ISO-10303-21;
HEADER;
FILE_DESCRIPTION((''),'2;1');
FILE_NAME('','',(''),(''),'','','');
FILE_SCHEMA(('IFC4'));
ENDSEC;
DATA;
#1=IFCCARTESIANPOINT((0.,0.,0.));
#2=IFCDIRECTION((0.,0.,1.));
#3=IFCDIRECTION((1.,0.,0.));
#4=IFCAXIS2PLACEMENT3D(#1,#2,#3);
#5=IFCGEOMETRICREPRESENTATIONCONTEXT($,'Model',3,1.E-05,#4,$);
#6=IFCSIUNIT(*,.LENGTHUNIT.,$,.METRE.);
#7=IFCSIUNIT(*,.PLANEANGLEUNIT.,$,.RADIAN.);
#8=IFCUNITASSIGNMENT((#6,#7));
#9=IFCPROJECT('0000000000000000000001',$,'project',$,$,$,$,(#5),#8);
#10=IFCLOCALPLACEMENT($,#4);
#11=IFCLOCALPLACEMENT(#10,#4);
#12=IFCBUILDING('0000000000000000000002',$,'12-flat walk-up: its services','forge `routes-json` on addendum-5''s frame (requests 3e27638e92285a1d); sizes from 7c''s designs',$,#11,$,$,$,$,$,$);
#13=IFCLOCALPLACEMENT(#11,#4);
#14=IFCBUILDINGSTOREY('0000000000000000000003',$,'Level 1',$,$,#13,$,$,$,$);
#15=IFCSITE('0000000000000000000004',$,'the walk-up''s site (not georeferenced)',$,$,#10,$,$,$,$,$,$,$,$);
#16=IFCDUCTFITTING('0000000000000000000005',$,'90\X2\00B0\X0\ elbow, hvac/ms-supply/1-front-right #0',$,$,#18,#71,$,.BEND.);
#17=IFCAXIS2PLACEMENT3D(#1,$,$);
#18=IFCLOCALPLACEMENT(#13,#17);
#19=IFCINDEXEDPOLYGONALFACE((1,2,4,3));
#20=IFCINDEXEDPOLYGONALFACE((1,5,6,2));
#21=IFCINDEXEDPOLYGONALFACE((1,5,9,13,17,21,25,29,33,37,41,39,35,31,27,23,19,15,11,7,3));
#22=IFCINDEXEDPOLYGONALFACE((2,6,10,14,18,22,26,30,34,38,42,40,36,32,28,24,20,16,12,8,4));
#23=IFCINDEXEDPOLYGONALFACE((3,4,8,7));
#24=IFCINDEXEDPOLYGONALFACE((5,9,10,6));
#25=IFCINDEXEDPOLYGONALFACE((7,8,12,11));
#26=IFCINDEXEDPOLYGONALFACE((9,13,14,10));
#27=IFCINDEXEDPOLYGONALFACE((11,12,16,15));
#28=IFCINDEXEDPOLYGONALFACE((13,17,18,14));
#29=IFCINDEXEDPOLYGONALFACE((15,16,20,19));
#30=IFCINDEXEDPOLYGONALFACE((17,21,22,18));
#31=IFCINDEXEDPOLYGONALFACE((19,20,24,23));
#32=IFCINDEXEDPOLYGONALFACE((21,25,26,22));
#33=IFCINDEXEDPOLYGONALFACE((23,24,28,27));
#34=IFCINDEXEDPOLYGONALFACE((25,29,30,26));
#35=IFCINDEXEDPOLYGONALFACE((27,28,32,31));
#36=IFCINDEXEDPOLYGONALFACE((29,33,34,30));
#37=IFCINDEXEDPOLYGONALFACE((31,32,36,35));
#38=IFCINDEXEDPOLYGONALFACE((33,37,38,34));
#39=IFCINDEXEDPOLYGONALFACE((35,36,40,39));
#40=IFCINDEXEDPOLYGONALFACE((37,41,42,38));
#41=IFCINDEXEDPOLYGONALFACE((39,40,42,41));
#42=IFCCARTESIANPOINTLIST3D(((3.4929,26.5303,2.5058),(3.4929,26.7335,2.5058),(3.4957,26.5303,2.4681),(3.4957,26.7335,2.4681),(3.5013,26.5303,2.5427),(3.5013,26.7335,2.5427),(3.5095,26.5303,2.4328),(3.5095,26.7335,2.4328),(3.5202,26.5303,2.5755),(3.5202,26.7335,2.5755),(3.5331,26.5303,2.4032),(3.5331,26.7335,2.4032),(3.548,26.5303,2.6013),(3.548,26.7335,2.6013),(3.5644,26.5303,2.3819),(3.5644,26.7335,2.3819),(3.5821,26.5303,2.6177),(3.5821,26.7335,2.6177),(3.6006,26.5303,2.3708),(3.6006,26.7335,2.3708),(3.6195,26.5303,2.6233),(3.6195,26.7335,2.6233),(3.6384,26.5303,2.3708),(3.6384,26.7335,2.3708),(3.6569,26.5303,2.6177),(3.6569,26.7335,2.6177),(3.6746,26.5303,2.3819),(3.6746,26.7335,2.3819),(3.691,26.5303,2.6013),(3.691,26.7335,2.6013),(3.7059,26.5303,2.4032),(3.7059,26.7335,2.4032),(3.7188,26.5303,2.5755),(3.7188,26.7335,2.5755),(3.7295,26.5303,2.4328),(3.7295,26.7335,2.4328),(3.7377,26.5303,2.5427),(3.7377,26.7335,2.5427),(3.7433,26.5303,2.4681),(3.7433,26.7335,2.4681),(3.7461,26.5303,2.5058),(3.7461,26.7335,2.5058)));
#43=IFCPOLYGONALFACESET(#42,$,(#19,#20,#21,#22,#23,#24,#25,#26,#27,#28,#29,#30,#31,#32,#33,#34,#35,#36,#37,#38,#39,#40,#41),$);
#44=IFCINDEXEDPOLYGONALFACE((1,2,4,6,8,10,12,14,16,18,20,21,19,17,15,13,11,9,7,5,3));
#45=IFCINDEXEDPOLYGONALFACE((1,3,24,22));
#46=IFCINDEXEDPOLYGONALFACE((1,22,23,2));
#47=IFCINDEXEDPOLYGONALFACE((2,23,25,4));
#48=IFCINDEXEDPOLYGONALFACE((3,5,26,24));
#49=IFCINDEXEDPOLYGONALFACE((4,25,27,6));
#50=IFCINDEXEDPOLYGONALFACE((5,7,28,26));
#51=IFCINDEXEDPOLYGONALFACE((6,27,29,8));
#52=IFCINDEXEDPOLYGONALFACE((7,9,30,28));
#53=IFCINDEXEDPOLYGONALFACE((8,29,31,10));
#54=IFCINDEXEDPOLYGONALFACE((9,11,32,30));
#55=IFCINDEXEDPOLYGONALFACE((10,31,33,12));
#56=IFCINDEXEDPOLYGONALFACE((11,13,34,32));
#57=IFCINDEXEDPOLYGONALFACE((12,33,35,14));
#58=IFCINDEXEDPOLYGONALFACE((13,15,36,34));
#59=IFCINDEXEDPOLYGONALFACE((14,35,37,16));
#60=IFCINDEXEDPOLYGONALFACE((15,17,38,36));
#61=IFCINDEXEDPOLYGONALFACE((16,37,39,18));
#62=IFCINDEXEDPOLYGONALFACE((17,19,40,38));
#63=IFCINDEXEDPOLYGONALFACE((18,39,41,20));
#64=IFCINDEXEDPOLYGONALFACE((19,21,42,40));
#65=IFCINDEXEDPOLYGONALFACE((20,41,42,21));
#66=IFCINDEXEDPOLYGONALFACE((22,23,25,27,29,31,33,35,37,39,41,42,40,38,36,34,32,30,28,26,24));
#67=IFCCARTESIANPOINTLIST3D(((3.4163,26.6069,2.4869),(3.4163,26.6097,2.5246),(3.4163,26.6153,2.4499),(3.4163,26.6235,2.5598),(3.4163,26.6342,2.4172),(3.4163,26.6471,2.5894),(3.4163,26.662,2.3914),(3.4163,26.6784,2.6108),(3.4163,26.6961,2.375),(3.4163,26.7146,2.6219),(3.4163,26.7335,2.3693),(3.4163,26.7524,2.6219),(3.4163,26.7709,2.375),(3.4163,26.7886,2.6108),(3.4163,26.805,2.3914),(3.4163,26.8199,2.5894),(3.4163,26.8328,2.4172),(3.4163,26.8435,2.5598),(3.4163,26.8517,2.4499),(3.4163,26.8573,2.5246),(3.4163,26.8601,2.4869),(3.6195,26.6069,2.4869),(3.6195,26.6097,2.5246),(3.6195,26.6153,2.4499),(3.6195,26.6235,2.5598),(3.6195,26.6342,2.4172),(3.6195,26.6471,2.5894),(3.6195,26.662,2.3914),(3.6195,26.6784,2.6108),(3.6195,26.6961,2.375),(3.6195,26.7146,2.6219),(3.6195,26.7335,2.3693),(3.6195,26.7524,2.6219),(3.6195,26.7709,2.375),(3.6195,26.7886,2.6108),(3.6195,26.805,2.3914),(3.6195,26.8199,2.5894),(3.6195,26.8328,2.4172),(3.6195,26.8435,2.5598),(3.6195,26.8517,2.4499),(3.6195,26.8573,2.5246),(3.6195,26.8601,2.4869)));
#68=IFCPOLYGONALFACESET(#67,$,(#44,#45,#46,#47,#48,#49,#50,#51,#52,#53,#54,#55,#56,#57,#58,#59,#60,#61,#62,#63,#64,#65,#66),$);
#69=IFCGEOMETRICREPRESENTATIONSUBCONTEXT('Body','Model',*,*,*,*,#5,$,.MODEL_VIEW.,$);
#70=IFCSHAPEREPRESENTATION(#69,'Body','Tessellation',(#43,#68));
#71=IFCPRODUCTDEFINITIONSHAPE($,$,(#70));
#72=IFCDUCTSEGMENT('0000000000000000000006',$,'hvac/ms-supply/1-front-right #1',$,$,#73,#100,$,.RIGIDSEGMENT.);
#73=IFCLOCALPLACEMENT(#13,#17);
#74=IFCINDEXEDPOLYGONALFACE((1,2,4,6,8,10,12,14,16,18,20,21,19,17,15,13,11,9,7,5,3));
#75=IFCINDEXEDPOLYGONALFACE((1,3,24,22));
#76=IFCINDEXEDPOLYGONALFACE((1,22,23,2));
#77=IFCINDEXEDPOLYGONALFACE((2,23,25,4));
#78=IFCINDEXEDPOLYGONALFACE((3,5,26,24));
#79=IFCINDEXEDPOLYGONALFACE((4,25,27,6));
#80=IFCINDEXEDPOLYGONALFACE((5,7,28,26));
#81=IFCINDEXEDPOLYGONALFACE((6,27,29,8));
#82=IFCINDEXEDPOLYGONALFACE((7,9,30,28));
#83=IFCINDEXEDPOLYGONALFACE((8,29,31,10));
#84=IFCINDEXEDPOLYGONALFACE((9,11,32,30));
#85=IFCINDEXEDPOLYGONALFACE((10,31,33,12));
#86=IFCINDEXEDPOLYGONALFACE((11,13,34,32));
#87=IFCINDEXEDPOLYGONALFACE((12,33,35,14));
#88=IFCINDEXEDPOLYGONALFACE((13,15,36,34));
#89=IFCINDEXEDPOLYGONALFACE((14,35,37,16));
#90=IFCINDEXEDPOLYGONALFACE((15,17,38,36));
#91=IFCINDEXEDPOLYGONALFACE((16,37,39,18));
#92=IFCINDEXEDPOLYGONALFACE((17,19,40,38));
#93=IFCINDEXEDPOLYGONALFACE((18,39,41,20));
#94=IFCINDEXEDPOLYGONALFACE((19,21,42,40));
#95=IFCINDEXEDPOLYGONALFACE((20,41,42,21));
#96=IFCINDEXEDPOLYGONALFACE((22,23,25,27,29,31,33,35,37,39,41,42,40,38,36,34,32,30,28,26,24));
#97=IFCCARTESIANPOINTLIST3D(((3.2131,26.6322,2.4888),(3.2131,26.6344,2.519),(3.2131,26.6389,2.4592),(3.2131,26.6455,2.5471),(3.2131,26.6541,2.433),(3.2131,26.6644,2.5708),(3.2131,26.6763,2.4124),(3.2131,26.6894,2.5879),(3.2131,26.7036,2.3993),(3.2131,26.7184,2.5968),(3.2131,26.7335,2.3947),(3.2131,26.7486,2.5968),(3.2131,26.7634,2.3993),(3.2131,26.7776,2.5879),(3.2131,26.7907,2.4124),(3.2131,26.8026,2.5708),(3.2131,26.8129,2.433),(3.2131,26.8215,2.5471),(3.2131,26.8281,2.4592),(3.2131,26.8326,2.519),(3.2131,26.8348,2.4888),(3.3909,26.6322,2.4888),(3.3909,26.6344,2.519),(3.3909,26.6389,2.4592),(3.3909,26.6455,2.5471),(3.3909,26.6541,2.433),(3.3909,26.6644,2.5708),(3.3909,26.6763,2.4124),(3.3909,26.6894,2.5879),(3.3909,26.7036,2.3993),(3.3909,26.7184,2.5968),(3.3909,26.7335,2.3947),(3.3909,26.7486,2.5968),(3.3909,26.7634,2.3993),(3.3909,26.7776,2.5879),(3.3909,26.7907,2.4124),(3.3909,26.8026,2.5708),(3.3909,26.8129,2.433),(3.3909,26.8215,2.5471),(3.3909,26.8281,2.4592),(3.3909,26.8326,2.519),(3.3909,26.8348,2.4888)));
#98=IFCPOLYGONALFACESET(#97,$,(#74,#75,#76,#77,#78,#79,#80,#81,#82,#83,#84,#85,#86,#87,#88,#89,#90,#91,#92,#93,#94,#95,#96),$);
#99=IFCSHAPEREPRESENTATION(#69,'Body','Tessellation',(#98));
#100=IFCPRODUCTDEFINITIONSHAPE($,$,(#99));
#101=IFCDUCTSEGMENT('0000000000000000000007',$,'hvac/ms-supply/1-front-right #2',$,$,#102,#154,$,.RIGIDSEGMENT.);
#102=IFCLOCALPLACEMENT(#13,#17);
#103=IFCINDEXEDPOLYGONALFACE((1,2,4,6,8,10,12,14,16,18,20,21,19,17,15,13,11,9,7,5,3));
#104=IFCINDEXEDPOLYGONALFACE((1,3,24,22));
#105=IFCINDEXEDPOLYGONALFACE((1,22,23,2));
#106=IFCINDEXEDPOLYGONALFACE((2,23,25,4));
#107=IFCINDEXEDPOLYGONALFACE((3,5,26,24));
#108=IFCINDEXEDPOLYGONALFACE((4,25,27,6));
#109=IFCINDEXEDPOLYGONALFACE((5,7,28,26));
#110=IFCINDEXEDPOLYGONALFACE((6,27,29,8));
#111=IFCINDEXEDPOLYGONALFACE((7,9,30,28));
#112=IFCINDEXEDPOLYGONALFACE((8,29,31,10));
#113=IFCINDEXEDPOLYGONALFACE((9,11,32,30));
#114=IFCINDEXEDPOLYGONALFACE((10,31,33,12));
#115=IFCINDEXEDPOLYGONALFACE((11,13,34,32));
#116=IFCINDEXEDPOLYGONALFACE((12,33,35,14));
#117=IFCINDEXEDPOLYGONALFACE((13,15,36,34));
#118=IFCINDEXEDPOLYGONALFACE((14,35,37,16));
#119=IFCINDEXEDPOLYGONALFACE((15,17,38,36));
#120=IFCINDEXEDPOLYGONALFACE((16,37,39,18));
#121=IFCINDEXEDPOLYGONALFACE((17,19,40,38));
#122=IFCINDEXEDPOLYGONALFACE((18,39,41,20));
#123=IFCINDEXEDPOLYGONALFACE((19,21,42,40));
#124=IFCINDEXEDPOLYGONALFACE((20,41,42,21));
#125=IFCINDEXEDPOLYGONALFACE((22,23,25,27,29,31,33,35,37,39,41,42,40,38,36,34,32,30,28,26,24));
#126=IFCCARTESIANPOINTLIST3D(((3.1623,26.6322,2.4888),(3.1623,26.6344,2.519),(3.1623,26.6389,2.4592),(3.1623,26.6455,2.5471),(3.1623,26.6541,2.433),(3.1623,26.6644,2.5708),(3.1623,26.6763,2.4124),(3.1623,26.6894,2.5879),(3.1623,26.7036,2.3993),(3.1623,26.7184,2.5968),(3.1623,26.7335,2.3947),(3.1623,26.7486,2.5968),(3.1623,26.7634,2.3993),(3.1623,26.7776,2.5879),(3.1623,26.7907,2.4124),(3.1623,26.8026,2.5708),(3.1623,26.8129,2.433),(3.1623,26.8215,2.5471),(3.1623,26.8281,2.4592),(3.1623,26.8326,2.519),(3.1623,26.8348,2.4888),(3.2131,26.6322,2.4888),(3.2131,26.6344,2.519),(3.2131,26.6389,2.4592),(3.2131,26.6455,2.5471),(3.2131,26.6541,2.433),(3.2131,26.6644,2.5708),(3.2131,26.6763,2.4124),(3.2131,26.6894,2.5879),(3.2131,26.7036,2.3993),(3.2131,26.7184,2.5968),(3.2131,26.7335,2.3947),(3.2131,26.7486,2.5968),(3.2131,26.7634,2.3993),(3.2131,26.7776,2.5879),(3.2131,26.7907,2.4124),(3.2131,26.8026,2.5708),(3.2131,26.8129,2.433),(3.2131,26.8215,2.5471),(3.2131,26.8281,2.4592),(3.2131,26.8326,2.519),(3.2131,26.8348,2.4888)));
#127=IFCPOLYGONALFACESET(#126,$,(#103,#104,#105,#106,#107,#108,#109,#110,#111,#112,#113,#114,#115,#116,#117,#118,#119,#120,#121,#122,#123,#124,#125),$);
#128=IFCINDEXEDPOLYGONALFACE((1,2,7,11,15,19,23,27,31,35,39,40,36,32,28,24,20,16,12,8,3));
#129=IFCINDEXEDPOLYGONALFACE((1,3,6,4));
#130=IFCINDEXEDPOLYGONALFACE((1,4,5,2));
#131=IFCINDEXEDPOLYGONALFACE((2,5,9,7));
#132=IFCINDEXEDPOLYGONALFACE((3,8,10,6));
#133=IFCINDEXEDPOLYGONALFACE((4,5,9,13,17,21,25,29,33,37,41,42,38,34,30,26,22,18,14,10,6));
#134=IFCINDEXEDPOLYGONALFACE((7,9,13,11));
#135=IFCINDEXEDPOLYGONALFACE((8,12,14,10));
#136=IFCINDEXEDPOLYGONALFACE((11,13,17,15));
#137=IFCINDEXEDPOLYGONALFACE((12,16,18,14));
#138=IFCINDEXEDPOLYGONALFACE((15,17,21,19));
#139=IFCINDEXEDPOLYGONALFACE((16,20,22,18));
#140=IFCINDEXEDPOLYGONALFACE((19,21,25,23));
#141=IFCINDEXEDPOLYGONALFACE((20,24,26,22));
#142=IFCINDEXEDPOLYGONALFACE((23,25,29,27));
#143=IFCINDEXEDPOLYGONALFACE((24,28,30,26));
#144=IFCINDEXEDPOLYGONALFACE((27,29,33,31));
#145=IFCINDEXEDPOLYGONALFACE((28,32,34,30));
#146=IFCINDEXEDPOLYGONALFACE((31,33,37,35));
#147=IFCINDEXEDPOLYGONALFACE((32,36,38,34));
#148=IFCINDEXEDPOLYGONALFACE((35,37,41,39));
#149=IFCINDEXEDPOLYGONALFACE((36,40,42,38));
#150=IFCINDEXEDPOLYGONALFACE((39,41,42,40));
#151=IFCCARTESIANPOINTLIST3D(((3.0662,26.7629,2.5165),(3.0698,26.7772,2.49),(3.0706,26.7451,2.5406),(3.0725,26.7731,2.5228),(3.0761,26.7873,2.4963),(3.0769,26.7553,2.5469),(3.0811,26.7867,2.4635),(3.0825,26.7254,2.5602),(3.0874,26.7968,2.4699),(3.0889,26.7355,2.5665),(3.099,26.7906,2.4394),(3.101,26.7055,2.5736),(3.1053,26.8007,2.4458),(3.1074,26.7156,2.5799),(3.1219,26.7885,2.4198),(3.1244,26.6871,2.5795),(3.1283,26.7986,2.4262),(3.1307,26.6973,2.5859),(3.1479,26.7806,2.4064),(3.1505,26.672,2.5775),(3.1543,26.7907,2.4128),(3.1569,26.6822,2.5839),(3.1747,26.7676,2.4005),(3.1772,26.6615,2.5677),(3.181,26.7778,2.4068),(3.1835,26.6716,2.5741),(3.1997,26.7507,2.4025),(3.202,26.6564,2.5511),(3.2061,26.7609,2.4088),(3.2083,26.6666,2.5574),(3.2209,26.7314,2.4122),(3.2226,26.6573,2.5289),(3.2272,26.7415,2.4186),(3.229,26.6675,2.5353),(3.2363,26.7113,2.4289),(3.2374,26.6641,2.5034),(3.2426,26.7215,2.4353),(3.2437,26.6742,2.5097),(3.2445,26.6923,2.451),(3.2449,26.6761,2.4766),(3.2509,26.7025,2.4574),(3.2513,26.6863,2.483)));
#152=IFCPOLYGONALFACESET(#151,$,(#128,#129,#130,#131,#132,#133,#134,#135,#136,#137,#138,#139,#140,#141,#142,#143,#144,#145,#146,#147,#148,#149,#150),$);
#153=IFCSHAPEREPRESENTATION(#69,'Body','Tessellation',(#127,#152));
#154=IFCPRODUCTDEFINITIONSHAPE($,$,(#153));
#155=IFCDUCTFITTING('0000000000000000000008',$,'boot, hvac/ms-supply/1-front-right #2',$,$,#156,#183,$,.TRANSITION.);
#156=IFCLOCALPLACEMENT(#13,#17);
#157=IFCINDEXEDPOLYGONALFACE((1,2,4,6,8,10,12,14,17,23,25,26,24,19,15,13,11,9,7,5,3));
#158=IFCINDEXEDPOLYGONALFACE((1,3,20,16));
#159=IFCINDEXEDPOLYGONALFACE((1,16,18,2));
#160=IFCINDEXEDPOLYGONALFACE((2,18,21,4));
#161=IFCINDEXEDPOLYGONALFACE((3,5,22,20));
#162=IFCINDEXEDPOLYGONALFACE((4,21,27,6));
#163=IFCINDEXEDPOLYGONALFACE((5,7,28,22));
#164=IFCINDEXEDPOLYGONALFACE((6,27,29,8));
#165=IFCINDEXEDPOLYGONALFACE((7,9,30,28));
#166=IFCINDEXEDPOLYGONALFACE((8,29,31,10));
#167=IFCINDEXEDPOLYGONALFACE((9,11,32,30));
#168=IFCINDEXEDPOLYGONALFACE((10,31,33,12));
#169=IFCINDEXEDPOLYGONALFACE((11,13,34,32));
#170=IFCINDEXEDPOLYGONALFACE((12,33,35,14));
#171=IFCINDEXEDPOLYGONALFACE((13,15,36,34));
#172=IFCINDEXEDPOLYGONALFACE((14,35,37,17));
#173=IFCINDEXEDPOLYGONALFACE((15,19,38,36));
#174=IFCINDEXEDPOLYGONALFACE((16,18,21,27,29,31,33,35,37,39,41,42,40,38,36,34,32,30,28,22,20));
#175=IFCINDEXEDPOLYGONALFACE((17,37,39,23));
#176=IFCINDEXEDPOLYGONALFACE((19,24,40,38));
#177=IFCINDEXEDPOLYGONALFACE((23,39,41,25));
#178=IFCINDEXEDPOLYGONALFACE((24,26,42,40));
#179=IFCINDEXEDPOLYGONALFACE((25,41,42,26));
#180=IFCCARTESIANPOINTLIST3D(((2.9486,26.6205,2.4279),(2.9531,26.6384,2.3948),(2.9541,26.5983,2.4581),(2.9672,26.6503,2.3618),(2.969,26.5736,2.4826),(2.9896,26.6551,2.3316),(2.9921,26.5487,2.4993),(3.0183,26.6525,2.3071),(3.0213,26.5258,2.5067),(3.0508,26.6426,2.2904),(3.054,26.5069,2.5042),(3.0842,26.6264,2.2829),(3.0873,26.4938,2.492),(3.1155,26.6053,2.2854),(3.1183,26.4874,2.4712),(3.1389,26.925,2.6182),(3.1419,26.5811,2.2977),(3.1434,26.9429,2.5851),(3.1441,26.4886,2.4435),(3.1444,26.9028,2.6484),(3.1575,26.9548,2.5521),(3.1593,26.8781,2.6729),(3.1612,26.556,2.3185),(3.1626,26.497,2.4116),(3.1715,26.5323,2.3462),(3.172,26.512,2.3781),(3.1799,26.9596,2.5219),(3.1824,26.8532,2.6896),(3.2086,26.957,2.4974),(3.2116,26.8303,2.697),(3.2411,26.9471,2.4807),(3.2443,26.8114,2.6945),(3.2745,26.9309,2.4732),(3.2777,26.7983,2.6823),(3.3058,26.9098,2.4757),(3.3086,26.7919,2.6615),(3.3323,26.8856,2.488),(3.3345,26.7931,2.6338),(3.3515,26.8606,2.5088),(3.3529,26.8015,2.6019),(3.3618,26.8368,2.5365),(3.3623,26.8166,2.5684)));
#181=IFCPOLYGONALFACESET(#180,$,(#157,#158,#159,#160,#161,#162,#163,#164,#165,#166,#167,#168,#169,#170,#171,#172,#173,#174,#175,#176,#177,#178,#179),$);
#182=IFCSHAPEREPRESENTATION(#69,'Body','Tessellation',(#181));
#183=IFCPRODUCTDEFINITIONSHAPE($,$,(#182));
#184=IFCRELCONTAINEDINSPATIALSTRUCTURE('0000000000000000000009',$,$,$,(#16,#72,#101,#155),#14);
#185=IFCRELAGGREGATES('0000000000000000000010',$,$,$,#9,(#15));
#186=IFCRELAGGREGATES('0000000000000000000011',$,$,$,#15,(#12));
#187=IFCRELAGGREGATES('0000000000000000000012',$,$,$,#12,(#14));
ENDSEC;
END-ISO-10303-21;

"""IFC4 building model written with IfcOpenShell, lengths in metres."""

from ifc_helpers import new_model, entity, si_unit, frame, origin_with_axes, place, context, subcontext, project, spatial, element, save


model = new_model("IFC4")

# Units and contexts
model_context = context("Model", 3, precision=1e-05, world=origin_with_axes())
body_context = subcontext(model_context, "Body", "Model", "MODEL_VIEW")
ifc_project = project(units=[si_unit("LENGTHUNIT", "METRE"), si_unit("PLANEANGLEUNIT", "RADIAN")], contexts=[model_context])

# Site, building, storey
site_placement = place(None, origin_with_axes())
site = spatial("IfcSite", under=ifc_project, at=site_placement, Name="the walk-up's site (not georeferenced)")
building_placement = place(site_placement, origin_with_axes())
building = spatial("IfcBuilding", under=site, at=building_placement, Name="12-flat walk-up: its services", Description="forge `routes-json` on addendum-5's frame (requests 3e27638e92285a1d); sizes from 7c's designs")
storey_placement = place(building_placement, origin_with_axes())
storey = spatial("IfcBuildingStorey", under=building, at=storey_placement, Name="Level 1")

# Duct fitting
duct_fitting_1_placement = place(storey_placement, frame((3.6195, 26.5303, 2.4963), z_axis=(0.0, 0.0, 1.0), x_axis=(1.0, 0.0, 0.0)))
element("IfcDuctFitting", 1, at=duct_fitting_1_placement, inside=storey, Name="90° elbow, hvac/ms-supply/1-front-right #0", PredefinedType="BEND", context=body_context, shape_type="AdvancedSweptSolid", body=[
    entity("IfcSweptDiskSolid", entity("IfcPolyline", [entity("IfcCartesianPoint", [0.0, 0.0, 0.0]), entity("IfcCartesianPoint", [0.0, 0.2032, 0.0])]), 0.127),
    entity("IfcSweptDiskSolid", entity("IfcPolyline", [entity("IfcCartesianPoint", [0.0, 0.2032, 0.0]), entity("IfcCartesianPoint", [-0.2032, 0.2032, 0.0])]), 0.127),
])

# Duct segments
duct_segment_1_placement = place(storey_placement, frame((3.3909, 26.7335, 2.4963), z_axis=(0.0, 0.0, 1.0), x_axis=(1.0, 0.0, 0.0)))
element("IfcDuctSegment", 2, at=duct_segment_1_placement, inside=storey, Name="hvac/ms-supply/1-front-right #1", PredefinedType="RIGIDSEGMENT", context=body_context, shape_type="AdvancedSweptSolid", body=[
    entity("IfcSweptDiskSolid", entity("IfcPolyline", [entity("IfcCartesianPoint", [0.0, 0.0, 0.0]), entity("IfcCartesianPoint", [-0.1778, 0.0, 0.0])]), 0.1016),
])
duct_segment_2_placement = place(storey_placement, frame((3.2131, 26.7335, 2.4963), z_axis=(0.0, 0.0, 1.0), x_axis=(1.0, 0.0, 0.0)))
element("IfcDuctSegment", 3, at=duct_segment_2_placement, inside=storey, Name="hvac/ms-supply/1-front-right #2", PredefinedType="RIGIDSEGMENT", context=body_context, shape_type="AdvancedSweptSolid", body=[
    entity("IfcSweptDiskSolid", entity("IfcPolyline", [entity("IfcCartesianPoint", [0.0, 0.0, 0.0]), entity("IfcCartesianPoint", [-0.0508, 0.0, 0.0])]), 0.1016),
    entity("IfcSweptDiskSolid", entity("IfcPolyline", [entity("IfcCartesianPoint", [-0.0508, 0.0, 0.0]), entity("IfcCartesianPoint", [-0.0572, -0.0102, -0.0063])]), 0.1016),
])

# Duct fitting
duct_fitting_2_placement = place(storey_placement, frame((3.2511, 26.8756, 2.5851), z_axis=(0.0, 0.0, 1.0), x_axis=(1.0, 0.0, 0.0)))
element("IfcDuctFitting", 4, at=duct_fitting_2_placement, inside=storey, Name="boot, hvac/ms-supply/1-front-right #2", PredefinedType="TRANSITION", context=body_context, shape_type="AdvancedSweptSolid", body=[
    entity("IfcSweptDiskSolid", entity("IfcPolyline", [entity("IfcCartesianPoint", [0.0, 0.0, 0.0]), entity("IfcCartesianPoint", [-0.1903, -0.3045, -0.1903])]), 0.127),
])

save(model, "model.ifc")
